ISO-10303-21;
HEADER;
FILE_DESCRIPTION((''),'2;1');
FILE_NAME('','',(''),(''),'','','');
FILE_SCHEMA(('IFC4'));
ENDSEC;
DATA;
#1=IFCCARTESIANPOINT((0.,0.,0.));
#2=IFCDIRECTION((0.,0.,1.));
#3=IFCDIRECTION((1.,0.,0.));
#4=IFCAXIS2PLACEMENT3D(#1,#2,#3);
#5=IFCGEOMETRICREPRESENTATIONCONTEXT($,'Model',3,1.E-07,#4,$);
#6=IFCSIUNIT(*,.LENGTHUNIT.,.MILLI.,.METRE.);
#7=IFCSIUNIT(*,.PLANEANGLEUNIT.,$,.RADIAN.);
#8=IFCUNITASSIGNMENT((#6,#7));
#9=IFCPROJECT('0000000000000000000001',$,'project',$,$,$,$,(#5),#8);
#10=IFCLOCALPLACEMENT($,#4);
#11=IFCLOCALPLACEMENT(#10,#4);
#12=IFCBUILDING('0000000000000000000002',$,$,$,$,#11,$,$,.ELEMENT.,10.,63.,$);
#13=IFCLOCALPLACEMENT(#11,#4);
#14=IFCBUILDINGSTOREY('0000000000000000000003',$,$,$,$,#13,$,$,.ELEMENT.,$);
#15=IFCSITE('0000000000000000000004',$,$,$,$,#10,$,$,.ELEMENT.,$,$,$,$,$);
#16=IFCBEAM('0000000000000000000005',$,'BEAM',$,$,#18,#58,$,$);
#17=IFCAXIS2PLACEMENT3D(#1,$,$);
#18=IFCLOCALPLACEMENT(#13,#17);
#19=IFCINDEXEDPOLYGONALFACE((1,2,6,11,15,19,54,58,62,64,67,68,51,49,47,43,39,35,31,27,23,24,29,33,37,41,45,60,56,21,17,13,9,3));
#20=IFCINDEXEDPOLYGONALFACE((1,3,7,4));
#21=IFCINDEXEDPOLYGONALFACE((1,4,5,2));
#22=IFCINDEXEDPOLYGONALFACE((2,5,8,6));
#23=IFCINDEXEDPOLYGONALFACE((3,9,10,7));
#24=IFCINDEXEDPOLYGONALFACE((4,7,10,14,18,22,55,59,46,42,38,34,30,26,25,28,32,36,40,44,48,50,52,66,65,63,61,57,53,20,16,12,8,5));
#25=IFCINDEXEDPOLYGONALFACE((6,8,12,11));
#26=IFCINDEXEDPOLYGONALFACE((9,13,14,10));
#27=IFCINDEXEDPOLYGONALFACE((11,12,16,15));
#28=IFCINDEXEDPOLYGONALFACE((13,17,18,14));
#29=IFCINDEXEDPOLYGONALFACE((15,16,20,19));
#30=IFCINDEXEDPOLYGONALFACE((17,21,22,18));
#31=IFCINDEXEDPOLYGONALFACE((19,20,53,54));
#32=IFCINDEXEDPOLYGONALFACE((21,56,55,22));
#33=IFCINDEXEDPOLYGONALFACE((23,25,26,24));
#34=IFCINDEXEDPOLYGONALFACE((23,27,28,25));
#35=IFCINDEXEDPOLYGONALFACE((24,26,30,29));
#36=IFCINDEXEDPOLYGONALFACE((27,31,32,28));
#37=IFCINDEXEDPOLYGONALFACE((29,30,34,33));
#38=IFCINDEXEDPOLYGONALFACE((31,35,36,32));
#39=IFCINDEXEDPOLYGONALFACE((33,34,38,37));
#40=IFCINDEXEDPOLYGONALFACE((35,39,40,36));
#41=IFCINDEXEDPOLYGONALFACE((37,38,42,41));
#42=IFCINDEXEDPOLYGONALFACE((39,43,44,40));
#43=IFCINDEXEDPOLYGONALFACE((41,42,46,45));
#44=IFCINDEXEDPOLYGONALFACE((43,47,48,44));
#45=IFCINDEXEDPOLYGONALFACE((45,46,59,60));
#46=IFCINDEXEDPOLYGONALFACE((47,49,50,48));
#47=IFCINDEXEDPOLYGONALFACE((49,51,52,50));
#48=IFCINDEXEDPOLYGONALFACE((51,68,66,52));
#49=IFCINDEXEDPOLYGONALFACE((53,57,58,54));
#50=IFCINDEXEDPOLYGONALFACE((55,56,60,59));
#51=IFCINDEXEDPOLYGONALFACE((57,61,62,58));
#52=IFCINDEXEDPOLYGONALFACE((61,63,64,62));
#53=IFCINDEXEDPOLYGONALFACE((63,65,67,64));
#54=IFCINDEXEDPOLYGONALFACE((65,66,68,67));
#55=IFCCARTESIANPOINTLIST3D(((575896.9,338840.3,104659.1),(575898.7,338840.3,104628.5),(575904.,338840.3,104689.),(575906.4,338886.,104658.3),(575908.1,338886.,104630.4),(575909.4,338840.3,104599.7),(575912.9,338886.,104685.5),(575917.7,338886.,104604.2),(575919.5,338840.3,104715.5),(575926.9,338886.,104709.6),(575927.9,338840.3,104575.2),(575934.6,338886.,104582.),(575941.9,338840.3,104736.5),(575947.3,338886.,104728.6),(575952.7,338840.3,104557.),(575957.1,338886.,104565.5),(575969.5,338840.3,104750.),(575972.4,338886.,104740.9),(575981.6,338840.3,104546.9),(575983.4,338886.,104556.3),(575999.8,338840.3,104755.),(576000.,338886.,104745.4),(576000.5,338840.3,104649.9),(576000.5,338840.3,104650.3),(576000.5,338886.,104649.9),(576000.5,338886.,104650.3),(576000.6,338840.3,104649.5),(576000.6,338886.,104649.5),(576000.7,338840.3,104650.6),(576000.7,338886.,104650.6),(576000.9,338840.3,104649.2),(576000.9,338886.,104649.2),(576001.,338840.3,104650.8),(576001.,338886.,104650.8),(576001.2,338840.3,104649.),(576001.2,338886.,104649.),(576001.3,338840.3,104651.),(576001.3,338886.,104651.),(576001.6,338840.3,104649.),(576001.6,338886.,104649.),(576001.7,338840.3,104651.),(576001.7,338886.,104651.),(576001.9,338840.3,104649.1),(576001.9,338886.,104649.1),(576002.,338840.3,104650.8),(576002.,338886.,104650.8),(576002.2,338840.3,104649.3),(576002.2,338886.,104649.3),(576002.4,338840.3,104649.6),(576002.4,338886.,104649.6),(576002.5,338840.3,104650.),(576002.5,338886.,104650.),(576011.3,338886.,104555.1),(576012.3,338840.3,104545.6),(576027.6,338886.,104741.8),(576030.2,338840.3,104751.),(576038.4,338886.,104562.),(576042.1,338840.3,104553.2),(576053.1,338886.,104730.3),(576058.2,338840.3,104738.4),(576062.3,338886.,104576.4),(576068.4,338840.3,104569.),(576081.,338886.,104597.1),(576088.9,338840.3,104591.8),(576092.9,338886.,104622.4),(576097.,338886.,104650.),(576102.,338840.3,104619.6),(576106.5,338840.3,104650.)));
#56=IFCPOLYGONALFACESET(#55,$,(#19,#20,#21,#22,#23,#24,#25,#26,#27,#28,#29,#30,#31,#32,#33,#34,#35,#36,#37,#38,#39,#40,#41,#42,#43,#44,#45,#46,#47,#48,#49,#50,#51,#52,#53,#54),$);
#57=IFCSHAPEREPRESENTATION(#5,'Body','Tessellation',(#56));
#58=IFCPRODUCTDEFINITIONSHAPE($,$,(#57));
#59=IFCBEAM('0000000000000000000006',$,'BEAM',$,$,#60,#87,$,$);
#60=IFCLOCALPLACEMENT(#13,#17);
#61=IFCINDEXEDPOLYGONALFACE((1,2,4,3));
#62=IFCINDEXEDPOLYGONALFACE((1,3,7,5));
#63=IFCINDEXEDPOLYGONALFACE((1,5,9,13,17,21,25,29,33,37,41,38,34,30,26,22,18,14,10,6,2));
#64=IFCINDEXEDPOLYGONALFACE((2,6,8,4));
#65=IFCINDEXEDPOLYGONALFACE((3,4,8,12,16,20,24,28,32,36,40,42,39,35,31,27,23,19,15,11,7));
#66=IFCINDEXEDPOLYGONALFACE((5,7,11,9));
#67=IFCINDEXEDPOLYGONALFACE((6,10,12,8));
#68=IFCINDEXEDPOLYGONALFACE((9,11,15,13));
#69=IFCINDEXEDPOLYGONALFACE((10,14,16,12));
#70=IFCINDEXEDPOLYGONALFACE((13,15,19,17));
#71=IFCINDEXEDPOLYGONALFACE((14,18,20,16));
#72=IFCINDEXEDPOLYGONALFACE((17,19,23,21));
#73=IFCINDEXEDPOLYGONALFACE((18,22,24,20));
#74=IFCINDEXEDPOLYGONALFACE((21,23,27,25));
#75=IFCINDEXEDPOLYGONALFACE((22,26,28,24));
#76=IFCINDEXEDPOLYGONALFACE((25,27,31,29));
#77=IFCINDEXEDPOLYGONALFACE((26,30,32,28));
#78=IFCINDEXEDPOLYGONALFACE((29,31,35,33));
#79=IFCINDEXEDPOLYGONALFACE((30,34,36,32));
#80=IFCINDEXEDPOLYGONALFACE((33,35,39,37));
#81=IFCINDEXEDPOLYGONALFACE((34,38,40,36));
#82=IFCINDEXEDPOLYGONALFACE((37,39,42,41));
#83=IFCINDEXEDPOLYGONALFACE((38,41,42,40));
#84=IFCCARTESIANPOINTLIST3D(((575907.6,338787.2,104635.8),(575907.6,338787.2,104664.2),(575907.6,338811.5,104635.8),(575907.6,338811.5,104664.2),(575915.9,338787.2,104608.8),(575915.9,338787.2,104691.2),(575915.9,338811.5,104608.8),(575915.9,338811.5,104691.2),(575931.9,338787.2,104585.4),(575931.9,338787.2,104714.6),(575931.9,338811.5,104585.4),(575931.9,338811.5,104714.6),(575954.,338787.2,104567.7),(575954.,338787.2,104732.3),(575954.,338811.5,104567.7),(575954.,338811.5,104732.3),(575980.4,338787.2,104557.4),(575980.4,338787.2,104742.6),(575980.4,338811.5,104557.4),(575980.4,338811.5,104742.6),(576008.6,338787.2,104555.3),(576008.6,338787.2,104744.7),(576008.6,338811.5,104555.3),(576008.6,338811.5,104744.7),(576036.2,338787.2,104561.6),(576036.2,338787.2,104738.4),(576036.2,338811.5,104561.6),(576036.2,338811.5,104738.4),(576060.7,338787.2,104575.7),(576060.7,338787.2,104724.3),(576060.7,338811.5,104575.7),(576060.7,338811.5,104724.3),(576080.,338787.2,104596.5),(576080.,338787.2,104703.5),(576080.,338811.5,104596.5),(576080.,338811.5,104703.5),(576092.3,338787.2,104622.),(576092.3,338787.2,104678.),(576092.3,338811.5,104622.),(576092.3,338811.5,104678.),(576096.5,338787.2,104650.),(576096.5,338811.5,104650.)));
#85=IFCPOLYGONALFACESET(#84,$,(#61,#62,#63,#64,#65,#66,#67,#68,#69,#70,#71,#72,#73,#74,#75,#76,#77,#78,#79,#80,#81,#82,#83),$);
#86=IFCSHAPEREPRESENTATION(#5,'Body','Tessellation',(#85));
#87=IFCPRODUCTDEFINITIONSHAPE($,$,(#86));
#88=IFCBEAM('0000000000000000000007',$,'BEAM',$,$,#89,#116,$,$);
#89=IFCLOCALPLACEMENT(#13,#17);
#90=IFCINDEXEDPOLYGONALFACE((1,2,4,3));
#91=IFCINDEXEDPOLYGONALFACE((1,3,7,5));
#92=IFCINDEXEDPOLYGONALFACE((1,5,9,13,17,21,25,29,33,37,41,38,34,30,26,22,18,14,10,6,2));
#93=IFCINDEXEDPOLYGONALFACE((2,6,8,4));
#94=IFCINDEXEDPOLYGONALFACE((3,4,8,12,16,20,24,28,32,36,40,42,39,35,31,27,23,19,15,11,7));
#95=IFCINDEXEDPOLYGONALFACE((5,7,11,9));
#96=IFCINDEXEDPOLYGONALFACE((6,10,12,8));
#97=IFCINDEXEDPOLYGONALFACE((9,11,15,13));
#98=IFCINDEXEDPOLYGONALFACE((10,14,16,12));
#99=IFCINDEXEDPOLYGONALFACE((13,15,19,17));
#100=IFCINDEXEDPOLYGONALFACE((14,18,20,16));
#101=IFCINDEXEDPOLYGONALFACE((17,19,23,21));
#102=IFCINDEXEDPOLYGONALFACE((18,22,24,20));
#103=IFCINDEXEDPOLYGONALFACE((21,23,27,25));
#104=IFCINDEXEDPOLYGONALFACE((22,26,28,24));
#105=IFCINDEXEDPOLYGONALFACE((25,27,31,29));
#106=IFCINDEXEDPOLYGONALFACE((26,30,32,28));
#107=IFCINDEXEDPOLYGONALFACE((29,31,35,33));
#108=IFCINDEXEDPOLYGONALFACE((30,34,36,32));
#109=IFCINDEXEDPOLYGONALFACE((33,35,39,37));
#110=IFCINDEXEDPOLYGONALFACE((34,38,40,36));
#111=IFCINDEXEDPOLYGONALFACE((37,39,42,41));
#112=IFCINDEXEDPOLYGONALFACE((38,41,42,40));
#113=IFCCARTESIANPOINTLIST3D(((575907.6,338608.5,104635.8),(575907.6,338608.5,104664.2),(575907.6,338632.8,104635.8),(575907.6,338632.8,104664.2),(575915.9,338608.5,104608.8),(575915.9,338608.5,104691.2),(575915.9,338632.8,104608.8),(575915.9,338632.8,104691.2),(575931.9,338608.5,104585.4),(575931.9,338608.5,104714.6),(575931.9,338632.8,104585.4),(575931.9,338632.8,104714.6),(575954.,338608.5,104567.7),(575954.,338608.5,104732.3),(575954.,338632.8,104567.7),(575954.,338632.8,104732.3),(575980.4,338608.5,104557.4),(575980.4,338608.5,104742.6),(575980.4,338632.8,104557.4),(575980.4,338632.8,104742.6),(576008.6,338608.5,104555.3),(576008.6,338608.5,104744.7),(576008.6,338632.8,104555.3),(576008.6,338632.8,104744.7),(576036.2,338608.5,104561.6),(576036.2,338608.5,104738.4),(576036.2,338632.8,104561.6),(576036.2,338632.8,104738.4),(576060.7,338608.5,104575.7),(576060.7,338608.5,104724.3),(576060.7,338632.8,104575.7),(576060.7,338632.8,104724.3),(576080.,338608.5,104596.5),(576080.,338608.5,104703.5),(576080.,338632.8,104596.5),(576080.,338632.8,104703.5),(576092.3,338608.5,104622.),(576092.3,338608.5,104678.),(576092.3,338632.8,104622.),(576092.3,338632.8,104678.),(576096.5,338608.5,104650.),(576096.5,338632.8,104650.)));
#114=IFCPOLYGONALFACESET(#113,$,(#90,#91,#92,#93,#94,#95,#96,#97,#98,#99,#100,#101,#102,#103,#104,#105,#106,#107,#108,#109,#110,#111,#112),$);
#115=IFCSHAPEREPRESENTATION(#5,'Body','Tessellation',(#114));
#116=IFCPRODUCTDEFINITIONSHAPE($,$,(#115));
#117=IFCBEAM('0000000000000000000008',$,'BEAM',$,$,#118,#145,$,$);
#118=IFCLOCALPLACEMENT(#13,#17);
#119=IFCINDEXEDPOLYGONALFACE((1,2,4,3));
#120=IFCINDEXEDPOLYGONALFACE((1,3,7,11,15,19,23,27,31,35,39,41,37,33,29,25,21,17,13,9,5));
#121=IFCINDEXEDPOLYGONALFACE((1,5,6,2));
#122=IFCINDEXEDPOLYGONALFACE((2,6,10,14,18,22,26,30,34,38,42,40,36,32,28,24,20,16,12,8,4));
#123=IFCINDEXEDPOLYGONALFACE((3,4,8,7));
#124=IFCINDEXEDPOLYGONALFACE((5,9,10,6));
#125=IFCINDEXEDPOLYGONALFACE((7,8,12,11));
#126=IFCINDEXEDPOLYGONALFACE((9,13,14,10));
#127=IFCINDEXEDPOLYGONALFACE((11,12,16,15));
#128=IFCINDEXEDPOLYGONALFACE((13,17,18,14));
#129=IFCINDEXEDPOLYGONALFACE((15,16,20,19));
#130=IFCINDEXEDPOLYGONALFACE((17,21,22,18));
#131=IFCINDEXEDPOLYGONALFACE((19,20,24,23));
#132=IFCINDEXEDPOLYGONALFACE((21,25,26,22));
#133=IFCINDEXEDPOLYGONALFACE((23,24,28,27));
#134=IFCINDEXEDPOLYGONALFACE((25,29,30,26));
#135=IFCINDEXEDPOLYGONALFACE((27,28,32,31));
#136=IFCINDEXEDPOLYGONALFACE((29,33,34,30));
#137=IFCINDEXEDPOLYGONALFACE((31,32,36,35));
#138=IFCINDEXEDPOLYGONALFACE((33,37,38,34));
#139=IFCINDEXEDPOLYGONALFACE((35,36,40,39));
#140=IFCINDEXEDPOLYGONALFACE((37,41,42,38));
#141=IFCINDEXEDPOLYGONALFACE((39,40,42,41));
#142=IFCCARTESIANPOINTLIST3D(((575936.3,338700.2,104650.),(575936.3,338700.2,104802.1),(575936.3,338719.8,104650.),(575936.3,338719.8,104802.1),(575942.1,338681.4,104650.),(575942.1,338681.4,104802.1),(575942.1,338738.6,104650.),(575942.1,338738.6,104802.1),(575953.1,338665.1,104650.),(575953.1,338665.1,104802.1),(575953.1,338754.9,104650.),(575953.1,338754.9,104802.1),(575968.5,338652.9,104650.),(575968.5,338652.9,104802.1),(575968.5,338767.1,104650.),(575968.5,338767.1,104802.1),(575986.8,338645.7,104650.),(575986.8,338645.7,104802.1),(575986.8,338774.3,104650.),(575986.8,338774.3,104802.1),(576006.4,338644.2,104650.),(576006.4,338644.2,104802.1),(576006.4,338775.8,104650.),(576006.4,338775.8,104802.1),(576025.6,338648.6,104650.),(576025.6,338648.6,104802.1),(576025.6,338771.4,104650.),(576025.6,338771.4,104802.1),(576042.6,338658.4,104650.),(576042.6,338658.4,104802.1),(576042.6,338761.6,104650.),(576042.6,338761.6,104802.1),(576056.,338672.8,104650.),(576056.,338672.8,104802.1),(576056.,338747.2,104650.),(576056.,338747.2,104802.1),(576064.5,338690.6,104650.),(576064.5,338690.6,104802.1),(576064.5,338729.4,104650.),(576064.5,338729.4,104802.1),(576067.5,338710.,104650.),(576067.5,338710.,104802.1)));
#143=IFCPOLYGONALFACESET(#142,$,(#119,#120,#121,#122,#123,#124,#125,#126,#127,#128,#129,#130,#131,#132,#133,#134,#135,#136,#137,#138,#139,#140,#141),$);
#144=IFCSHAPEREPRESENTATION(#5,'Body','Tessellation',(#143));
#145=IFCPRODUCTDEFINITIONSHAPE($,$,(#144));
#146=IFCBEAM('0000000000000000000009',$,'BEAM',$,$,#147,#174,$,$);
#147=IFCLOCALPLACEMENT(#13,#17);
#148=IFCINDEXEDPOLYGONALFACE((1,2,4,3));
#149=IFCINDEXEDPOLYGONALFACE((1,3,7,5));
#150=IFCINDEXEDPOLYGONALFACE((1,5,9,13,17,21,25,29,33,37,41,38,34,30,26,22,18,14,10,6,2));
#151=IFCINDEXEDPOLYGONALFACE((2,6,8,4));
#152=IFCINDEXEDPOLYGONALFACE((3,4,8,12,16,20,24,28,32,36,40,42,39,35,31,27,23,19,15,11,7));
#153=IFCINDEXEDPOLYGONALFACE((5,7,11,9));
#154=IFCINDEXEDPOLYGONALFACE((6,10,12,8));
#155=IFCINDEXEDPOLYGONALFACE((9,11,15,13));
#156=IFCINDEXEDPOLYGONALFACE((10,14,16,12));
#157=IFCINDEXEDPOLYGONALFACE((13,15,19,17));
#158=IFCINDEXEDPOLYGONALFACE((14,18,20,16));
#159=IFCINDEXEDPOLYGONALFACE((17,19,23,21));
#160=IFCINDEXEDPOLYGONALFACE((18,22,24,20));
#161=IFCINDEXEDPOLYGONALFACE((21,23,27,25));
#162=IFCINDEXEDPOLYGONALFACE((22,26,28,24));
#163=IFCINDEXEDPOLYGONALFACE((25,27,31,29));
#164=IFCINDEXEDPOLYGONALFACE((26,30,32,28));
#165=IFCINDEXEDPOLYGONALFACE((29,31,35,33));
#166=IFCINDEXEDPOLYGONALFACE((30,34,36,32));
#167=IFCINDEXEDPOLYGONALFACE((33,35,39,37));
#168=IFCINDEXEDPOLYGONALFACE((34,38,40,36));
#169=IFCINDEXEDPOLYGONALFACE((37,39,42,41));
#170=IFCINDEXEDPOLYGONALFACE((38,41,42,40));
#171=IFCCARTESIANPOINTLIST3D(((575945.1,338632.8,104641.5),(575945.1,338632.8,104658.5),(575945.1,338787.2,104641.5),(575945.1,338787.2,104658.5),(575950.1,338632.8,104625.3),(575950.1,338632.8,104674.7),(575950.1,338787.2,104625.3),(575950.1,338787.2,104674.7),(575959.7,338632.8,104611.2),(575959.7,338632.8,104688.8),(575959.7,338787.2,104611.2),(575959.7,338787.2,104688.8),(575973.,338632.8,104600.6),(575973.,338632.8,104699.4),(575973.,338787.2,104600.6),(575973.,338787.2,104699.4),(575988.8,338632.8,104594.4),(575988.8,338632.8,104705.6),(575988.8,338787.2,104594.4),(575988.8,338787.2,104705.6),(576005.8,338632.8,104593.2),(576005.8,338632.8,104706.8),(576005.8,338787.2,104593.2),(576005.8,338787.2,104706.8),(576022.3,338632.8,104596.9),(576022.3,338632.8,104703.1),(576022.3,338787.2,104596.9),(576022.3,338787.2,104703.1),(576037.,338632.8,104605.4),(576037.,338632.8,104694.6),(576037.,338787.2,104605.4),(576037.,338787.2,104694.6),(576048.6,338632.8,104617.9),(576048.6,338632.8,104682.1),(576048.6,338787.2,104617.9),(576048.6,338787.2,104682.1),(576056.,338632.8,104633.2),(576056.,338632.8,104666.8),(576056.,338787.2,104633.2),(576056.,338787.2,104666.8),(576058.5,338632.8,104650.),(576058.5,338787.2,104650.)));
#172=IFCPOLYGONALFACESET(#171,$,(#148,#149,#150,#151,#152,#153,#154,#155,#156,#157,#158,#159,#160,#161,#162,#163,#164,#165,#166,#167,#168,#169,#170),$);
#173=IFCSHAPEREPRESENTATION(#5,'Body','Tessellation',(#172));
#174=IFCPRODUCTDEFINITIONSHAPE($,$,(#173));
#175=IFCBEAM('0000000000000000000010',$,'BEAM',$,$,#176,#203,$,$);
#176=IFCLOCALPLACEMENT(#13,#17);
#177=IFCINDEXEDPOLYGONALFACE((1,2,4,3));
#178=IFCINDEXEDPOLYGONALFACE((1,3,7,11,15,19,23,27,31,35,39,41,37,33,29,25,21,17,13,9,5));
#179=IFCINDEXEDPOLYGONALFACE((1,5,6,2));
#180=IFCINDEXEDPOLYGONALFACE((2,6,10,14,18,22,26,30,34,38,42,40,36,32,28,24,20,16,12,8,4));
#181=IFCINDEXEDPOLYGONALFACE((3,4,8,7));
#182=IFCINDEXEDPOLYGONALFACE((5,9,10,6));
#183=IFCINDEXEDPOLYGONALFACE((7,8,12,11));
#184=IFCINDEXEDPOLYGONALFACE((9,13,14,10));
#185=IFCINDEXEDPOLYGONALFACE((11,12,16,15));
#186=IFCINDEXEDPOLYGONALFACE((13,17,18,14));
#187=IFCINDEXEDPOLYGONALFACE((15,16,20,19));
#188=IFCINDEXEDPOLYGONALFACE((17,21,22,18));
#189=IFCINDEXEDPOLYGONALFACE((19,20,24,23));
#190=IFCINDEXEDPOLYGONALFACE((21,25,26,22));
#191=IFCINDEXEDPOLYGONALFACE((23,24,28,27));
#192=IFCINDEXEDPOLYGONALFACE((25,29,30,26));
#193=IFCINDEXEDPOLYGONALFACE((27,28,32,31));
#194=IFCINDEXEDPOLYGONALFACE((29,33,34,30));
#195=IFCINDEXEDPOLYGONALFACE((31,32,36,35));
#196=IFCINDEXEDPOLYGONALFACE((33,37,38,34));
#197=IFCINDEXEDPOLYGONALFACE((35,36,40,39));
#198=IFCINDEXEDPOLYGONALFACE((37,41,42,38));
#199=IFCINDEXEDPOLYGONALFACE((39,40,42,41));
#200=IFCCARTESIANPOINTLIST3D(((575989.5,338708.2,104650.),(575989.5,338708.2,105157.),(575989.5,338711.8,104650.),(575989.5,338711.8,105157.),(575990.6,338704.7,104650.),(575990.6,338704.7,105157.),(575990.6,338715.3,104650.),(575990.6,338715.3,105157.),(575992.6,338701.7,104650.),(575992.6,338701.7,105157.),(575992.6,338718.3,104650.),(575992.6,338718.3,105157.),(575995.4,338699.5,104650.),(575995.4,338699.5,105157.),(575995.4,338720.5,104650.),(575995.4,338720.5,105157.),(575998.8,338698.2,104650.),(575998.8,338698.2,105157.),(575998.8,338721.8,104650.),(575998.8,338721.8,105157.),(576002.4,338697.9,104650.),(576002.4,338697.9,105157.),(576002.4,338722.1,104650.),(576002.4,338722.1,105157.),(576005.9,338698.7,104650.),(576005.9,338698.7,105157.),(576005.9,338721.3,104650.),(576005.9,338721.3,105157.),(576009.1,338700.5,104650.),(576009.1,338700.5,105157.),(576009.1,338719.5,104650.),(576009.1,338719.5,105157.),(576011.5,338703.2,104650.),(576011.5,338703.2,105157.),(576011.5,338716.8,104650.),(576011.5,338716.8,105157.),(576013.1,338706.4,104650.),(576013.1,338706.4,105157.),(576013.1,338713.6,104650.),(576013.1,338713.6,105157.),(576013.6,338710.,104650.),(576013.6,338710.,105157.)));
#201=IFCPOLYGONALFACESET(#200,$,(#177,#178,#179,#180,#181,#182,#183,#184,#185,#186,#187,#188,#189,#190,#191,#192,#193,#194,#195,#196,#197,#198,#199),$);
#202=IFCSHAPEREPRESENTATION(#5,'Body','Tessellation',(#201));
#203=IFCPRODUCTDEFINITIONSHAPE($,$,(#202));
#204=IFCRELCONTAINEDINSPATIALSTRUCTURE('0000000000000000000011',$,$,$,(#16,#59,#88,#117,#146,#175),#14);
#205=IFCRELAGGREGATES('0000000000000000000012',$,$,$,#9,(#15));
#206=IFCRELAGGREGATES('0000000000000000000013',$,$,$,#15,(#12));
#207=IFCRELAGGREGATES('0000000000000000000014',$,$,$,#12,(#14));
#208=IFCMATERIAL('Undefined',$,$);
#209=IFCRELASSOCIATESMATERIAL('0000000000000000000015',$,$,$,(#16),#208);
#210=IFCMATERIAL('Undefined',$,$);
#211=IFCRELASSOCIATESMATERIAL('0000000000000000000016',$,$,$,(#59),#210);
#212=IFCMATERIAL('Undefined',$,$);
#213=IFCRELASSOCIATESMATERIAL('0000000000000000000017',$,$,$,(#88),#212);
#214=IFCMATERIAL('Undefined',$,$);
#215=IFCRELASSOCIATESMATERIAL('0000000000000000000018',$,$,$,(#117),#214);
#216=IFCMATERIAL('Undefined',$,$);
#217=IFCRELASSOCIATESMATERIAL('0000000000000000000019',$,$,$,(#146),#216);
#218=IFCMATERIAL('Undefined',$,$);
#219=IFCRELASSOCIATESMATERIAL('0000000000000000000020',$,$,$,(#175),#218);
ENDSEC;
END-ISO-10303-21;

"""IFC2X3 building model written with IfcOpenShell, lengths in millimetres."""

from ifc_helpers import new_model, entity, si_unit, frame, origin_with_axes, origin_2d_with_axis, place, context, project, spatial, circle, extrude, material, element, save


model = new_model("IFC2X3")

# Units and contexts
model_context = context("Model", 3, precision=1e-07, world=origin_with_axes())
ifc_project = project(units=[si_unit("LENGTHUNIT", "METRE", prefix="MILLI"), si_unit("PLANEANGLEUNIT", "RADIAN")], contexts=[model_context])

# Site, building, storey
site_placement = place(None, origin_with_axes())
site = spatial("IfcSite", under=ifc_project, at=site_placement, CompositionType="ELEMENT")
building_placement = place(site_placement, origin_with_axes())
building = spatial("IfcBuilding", under=site, at=building_placement, CompositionType="ELEMENT", ElevationOfRefHeight=10.0, ElevationOfTerrain=63.0)
storey_placement = place(building_placement, origin_with_axes())
storey = spatial("IfcBuildingStorey", under=building, at=storey_placement, CompositionType="ELEMENT")

# Beams
ifc_material_1 = material(Name="Undefined")
beam_1_placement = place(storey_placement, frame((576001.5, 338863.2, 104650.0), z_axis=(0.0, 1.0, 0.0), x_axis=(0.0, 0.0, 1.0)))
element("IfcBeam", 1, at=beam_1_placement, inside=storey, material=ifc_material_1, Name="BEAM", context=model_context, shape_type="SweptSolid", body=[
    entity("IfcRevolvedAreaSolid", entity("IfcTrapeziumProfileDef", "AREA", None, entity("IfcAxis2Placement2D", entity("IfcCartesianPoint", [0.0, 53.0]), entity("IfcDirection", [0.0, 1.0])), 94.5, 104.0, 45.7, 0.0), entity("IfcAxis2Placement3D", entity("IfcCartesianPoint", [0.0, 0.0, 0.0]), entity("IfcDirection", [-1.0, 0.0, 0.0]), entity("IfcDirection", [0.0, 0.0, 1.0])), entity("IfcAxis1Placement", entity("IfcCartesianPoint", [0.0, 0.0, 0.0]), entity("IfcDirection", [1.0, 0.0, 0.0])), 5.283185),
])
ifc_material_2 = material(Name="Undefined")
beam_2_placement = place(storey_placement, frame((576001.5, 338799.3, 104650.0), z_axis=(0.0, 1.0, 0.0), x_axis=(0.0, 0.0, -1.0)))
element("IfcBeam", 2, at=beam_2_placement, inside=storey, material=ifc_material_2, Name="BEAM", context=model_context, shape_type="SweptSolid", body=[
    extrude(circle(Radius=95.0, at=origin_2d_with_axis()), frame((0.0, 0.0, -12.2), z_axis=(0.0, 0.0, 1.0), x_axis=(0.0, -1.0, 0.0)), (0.0, 0.0, 1.0), 24.3),
])
ifc_material_3 = material(Name="Undefined")
beam_3_placement = place(storey_placement, frame((576001.5, 338620.6, 104650.0), z_axis=(0.0, -1.0, 0.0), x_axis=(0.0, 0.0, 1.0)))
element("IfcBeam", 3, at=beam_3_placement, inside=storey, material=ifc_material_3, Name="BEAM", context=model_context, shape_type="SweptSolid", body=[
    extrude(circle(Radius=95.0, at=origin_2d_with_axis()), frame((0.0, 0.0, -12.2), z_axis=(0.0, 0.0, 1.0), x_axis=(0.0, -1.0, 0.0)), (0.0, 0.0, 1.0), 24.3),
])
ifc_material_4 = material(Name="Undefined")
beam_4_placement = place(storey_placement, frame((576001.5, 338710.0, 104726.1), z_axis=(0.0, 0.0, 1.0), x_axis=(0.0, 1.0, 0.0)))
element("IfcBeam", 4, at=beam_4_placement, inside=storey, material=ifc_material_4, Name="BEAM", context=model_context, shape_type="SweptSolid", body=[
    extrude(circle(Radius=66.0, at=origin_2d_with_axis()), frame((0.0, 0.0, -76.0), z_axis=(0.0, 0.0, 1.0), x_axis=(0.0, -1.0, 0.0)), (0.0, 0.0, 1.0), 152.1),
])
ifc_material_5 = material(Name="Undefined")
beam_5_placement = place(storey_placement, frame((576001.5, 338710.0, 104650.0), z_axis=(0.0, 1.0, 0.0), x_axis=(0.0, 0.0, -1.0)))
element("IfcBeam", 5, at=beam_5_placement, inside=storey, material=ifc_material_5, Name="BEAM", context=model_context, shape_type="SweptSolid", body=[
    extrude(circle(Radius=57.0, at=origin_2d_with_axis()), frame((0.0, 0.0, -77.2), z_axis=(0.0, 0.0, 1.0), x_axis=(0.0, -1.0, 0.0)), (0.0, 0.0, 1.0), 154.4),
])
ifc_material_6 = material(Name="Undefined")
beam_6_placement = place(storey_placement, frame((576001.5, 338710.0, 104903.5), z_axis=(0.0, 0.0, 1.0), x_axis=(0.0, 1.0, 0.0)))
element("IfcBeam", 6, at=beam_6_placement, inside=storey, material=ifc_material_6, Name="BEAM", context=model_context, shape_type="SweptSolid", body=[
    extrude(circle(Radius=12.2, at=origin_2d_with_axis()), frame((0.0, 0.0, -253.5), z_axis=(0.0, 0.0, 1.0), x_axis=(0.0, -1.0, 0.0)), (0.0, 0.0, 1.0), 507.0),
])

save(model, "model.ifc")
